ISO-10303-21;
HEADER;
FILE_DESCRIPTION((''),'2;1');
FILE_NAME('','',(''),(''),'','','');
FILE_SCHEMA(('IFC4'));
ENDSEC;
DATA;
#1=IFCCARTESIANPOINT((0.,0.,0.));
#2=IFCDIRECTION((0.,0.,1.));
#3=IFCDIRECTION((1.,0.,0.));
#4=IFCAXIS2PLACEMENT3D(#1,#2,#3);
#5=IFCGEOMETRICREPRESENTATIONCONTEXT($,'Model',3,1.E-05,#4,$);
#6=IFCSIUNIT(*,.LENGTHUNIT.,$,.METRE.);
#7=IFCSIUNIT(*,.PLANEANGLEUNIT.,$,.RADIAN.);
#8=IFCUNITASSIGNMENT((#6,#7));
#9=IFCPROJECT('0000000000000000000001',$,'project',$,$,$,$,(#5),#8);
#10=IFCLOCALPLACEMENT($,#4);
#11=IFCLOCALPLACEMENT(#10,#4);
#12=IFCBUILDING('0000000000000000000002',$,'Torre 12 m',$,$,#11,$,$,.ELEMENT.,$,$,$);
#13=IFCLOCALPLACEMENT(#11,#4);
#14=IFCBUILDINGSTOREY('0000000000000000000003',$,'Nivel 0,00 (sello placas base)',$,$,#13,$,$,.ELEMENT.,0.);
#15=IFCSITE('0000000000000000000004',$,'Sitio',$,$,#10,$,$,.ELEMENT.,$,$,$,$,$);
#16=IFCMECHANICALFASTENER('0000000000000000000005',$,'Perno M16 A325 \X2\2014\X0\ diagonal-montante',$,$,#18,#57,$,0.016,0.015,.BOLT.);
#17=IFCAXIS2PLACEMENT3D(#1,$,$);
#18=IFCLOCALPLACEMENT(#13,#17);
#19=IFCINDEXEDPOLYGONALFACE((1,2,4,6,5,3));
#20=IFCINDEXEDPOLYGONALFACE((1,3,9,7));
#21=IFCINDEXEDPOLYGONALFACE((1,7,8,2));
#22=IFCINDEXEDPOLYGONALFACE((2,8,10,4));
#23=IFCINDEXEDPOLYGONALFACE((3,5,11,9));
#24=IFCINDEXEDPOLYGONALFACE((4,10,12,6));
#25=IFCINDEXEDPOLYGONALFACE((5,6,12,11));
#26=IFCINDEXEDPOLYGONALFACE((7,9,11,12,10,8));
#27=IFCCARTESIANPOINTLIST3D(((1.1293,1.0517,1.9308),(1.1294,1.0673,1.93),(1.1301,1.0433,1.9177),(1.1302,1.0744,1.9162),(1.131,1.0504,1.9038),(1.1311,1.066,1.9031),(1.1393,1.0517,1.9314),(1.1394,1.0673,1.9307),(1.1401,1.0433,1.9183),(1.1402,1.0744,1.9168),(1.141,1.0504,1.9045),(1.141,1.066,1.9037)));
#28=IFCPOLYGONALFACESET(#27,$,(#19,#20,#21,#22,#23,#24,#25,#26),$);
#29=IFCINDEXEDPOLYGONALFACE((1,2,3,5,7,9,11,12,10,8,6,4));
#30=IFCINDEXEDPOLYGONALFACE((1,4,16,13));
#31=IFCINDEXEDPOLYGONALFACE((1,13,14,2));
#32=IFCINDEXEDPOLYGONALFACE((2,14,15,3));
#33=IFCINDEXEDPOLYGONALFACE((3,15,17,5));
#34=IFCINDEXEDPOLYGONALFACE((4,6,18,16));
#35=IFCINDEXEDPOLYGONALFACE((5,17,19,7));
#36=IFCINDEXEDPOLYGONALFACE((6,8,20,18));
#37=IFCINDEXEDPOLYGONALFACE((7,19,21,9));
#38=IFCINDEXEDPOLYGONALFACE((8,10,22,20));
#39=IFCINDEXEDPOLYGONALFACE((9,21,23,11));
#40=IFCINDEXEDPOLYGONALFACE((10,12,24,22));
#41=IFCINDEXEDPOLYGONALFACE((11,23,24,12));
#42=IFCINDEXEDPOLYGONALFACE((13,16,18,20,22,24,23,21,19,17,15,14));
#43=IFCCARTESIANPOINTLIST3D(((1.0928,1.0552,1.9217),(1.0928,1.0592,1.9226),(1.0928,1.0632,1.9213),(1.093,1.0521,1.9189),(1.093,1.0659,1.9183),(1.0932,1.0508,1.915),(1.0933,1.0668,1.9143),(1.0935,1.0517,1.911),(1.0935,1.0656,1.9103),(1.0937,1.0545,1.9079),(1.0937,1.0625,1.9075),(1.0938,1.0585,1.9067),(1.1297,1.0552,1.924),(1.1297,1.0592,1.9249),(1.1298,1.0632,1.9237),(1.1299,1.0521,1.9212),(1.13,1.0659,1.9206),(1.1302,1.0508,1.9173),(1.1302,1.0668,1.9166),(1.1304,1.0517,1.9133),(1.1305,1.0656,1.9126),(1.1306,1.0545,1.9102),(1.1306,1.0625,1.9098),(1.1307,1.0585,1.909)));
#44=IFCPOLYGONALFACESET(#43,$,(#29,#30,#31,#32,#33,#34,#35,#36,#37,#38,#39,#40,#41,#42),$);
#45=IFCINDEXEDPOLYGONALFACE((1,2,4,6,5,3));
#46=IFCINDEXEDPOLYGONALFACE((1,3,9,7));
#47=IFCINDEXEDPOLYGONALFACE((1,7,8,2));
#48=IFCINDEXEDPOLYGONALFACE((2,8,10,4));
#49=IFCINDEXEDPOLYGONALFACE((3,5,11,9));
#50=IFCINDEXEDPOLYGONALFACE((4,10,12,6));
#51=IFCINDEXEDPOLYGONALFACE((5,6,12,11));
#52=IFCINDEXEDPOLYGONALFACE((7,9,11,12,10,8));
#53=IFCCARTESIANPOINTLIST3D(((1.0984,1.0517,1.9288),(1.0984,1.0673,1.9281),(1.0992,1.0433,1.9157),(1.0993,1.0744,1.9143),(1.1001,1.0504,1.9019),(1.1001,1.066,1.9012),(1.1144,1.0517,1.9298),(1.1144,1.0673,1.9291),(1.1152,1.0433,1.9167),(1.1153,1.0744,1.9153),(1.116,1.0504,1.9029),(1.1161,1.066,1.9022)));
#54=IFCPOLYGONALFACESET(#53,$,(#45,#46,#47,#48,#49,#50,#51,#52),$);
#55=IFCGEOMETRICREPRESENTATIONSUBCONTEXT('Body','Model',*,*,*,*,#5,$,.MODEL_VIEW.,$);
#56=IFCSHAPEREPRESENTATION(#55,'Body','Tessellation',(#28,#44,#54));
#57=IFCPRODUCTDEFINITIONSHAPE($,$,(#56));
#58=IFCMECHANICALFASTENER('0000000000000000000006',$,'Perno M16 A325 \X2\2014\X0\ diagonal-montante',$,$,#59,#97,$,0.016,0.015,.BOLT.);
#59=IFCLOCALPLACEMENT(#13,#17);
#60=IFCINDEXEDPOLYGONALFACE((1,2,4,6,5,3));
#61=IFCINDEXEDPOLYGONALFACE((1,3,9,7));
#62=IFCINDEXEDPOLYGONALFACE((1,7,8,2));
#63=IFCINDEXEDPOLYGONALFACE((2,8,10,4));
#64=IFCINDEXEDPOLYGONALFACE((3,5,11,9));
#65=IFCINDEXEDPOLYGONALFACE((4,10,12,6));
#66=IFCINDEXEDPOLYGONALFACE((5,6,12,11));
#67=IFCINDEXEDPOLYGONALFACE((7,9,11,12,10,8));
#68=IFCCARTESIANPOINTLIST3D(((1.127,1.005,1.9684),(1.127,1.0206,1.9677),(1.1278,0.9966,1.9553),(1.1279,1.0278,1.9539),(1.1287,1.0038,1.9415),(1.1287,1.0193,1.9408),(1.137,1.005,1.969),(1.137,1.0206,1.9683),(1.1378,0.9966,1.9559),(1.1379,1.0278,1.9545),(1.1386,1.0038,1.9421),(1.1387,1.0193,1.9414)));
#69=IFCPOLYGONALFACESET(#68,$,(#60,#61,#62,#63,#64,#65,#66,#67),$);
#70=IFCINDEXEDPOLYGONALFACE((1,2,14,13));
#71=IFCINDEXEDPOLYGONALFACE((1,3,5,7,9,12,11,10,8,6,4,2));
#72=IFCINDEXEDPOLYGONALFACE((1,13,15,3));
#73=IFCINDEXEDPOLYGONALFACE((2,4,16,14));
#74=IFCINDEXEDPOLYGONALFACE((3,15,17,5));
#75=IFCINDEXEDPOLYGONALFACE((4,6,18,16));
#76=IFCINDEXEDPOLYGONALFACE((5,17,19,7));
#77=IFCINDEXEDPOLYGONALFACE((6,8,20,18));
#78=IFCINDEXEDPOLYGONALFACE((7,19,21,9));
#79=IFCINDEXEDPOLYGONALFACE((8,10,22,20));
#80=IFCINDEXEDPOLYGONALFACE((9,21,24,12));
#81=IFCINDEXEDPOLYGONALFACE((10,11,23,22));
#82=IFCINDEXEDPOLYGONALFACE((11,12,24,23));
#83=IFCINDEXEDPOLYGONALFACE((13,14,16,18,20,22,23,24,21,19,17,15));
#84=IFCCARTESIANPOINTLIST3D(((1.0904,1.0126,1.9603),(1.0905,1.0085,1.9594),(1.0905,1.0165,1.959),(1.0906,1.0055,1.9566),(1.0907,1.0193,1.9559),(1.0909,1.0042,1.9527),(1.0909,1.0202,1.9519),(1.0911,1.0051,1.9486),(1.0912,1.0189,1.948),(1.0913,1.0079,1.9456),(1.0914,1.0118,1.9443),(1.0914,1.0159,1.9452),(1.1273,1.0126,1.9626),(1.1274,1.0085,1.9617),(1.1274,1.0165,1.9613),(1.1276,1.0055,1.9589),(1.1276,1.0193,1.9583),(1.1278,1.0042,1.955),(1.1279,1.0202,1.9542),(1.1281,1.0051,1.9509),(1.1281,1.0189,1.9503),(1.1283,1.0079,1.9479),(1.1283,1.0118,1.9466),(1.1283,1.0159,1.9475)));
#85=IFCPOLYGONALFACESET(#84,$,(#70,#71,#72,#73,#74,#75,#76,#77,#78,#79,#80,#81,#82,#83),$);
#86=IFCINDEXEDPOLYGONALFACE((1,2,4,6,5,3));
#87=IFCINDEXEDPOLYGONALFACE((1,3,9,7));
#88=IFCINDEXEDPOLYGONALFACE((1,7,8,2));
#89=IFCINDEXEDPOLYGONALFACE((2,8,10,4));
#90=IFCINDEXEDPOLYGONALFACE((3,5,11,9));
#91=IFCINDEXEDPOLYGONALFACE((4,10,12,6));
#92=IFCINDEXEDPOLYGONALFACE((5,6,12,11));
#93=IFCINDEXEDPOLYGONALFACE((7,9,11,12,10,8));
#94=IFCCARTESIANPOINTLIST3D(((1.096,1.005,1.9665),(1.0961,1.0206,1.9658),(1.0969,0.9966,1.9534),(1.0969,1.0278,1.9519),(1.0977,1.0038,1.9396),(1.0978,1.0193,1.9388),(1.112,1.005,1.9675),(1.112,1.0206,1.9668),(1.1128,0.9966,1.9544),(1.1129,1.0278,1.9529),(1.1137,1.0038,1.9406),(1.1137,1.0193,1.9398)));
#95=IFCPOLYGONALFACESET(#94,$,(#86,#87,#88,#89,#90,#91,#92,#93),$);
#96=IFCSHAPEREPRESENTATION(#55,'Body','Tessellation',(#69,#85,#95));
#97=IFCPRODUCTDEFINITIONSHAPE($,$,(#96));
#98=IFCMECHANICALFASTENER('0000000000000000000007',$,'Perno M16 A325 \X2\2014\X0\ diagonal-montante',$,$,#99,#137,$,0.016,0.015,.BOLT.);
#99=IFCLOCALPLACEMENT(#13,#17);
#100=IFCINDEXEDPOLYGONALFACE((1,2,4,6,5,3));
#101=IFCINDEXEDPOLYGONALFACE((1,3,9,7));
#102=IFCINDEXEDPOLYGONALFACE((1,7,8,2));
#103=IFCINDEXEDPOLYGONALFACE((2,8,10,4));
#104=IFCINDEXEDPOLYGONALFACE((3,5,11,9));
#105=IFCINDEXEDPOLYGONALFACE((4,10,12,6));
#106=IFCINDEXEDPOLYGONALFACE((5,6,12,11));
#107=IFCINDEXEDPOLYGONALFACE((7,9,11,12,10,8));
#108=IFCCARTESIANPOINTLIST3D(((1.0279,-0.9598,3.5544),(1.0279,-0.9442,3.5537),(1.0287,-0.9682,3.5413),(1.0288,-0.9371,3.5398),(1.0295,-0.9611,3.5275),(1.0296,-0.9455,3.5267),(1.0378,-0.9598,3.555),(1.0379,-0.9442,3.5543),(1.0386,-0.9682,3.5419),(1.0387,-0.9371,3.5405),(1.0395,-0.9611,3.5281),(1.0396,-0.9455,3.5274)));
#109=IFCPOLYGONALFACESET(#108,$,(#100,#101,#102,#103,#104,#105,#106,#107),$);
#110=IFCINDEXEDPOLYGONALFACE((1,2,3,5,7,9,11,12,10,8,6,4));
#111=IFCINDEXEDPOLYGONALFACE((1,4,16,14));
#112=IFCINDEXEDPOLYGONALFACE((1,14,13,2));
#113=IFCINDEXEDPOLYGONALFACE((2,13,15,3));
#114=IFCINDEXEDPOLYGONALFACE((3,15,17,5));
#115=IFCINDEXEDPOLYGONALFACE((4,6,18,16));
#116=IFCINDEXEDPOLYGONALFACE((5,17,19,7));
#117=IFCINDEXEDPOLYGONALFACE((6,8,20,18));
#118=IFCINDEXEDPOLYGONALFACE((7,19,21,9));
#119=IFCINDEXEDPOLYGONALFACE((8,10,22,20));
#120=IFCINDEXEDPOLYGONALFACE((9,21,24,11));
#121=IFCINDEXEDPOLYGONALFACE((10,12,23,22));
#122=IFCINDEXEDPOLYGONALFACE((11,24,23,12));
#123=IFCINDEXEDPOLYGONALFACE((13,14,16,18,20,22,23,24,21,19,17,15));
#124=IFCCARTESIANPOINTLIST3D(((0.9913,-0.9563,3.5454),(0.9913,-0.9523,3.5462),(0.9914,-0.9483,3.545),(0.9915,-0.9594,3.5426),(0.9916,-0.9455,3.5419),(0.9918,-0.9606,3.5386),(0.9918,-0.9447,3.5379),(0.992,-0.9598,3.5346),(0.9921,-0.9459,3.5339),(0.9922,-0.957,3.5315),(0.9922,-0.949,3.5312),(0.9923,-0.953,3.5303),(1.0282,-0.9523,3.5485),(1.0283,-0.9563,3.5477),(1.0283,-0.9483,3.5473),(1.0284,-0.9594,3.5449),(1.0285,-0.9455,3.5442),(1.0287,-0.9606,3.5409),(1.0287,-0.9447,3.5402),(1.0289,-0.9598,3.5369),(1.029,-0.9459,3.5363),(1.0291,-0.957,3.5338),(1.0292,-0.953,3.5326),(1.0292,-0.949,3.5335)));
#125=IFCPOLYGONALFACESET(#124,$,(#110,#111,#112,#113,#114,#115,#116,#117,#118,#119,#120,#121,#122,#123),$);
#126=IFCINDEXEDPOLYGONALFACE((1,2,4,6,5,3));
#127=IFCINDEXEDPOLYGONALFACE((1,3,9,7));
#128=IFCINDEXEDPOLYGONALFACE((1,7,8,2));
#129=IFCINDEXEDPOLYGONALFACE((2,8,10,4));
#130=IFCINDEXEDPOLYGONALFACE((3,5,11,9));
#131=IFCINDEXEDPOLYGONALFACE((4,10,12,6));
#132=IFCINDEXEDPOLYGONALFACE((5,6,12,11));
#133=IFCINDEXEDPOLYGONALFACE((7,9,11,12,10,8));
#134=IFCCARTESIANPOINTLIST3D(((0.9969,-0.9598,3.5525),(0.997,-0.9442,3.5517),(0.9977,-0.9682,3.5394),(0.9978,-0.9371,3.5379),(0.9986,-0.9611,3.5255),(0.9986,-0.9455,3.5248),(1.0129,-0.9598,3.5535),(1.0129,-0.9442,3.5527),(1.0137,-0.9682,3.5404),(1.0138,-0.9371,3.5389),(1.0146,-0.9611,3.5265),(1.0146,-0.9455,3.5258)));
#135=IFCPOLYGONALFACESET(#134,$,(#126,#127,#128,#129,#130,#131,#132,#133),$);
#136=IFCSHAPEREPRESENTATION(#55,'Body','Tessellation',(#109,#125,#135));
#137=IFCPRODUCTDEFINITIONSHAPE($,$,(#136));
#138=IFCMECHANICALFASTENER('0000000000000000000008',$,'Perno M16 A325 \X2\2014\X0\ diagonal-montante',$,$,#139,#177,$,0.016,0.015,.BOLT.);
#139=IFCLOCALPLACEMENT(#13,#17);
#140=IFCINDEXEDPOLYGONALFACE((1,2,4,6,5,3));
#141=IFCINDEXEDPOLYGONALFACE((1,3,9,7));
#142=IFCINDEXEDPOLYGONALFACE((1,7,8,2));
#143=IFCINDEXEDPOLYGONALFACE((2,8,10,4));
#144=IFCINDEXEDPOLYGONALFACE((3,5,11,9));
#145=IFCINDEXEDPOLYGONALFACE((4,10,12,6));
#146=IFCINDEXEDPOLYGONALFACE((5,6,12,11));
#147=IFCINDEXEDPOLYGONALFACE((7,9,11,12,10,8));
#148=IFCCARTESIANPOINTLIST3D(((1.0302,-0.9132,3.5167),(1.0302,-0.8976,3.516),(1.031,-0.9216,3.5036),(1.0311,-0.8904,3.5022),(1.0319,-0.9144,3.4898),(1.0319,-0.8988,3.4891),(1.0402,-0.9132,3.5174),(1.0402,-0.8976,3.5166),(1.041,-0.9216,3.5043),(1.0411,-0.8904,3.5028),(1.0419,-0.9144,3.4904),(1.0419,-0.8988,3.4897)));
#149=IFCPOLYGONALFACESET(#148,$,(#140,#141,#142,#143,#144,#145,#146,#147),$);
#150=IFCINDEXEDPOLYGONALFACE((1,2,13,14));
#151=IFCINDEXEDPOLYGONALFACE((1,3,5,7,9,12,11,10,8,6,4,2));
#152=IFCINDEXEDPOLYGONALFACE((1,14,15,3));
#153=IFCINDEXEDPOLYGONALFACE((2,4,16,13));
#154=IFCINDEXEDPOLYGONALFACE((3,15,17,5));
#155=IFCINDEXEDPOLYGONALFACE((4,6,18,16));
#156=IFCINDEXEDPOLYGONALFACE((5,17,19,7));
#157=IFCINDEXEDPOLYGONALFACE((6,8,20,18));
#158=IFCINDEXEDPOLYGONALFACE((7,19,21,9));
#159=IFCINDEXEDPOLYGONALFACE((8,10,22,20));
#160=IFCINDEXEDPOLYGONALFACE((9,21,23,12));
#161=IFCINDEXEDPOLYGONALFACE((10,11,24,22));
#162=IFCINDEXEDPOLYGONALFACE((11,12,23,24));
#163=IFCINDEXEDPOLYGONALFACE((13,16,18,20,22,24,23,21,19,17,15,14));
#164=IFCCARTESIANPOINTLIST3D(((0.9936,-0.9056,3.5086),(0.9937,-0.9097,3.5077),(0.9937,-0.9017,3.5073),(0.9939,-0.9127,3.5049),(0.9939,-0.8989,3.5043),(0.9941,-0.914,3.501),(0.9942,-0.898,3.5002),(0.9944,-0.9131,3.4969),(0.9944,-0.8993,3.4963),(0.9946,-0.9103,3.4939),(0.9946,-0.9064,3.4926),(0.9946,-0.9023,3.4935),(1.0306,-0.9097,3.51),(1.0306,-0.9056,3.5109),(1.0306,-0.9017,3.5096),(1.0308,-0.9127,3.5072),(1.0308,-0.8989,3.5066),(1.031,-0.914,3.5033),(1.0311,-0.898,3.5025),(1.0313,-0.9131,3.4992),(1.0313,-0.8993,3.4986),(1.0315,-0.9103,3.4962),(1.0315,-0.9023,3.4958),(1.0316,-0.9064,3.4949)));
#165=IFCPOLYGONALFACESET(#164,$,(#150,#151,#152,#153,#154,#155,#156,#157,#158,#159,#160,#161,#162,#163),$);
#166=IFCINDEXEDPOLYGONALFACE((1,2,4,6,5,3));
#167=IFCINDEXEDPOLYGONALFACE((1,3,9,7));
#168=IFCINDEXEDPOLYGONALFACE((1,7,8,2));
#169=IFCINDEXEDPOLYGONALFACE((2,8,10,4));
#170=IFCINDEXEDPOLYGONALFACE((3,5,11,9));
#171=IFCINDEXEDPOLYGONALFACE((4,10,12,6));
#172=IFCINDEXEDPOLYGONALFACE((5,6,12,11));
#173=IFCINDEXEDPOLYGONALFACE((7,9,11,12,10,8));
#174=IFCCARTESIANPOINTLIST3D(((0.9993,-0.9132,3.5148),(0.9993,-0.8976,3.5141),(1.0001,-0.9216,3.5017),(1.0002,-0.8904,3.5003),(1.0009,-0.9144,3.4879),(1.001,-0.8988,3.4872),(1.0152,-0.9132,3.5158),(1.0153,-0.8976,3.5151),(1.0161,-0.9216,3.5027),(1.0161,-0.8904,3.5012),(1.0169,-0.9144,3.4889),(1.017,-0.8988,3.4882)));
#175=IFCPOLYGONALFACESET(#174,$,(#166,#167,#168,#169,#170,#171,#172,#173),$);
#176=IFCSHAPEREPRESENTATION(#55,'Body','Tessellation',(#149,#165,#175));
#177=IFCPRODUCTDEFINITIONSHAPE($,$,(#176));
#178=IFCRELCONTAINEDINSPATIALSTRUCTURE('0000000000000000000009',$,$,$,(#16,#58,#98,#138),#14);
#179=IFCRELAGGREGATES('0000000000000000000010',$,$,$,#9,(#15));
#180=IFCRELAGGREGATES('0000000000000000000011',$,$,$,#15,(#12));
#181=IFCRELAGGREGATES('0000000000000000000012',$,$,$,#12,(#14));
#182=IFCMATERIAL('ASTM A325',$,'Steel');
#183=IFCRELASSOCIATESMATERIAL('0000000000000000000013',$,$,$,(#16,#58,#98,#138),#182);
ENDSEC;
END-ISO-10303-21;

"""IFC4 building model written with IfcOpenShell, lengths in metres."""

from ifc_helpers import new_model, si_unit, frame, origin_with_axes, place, context, subcontext, project, spatial, polyline, outline, extrude, material, element, save


model = new_model("IFC4")

# Units and contexts
model_context = context("Model", 3, precision=1e-05, world=origin_with_axes())
body_context = subcontext(model_context, "Body", "Model", "MODEL_VIEW")
ifc_project = project(units=[si_unit("LENGTHUNIT", "METRE"), si_unit("PLANEANGLEUNIT", "RADIAN")], contexts=[model_context])

# Site, building, storey
site_placement = place(None, origin_with_axes())
site = spatial("IfcSite", under=ifc_project, at=site_placement, Name="Sitio", CompositionType="ELEMENT")
building_placement = place(site_placement, origin_with_axes())
building = spatial("IfcBuilding", under=site, at=building_placement, Name="Torre 12 m", CompositionType="ELEMENT")
storey_placement = place(building_placement, origin_with_axes())
storey = spatial("IfcBuildingStorey", under=building, at=storey_placement, Name="Nivel 0,00 (sello placas base)", CompositionType="ELEMENT", Elevation=0.0)

# Shared definitions
placement = place(storey_placement, origin_with_axes())

# Mechanical fasteners
ifc_material_1 = material(Name="ASTM A325", Category="Steel")
element("IfcMechanicalFastener", 1, at=placement, inside=storey, material=ifc_material_1, Name="Perno M16 A325 — diagonal-montante", NominalDiameter=0.016, NominalLength=0.015, PredefinedType="BOLT", context=body_context, shape_type="SweptSolid", body=[
    extrude(outline(polyline([(0.0135, 0.0078), (0.0, 0.0156), (-0.0135, 0.0078), (-0.0135, -0.0078), (0.0, -0.0156), (0.0135, -0.0078), (0.0135, 0.0078)])), frame((1.1402, 1.0588, 1.9176), z_axis=(-0.998053, 0.0, -0.062378), x_axis=(0.033672, 0.841794, -0.538748)), (0.0, 0.0, 1.0), 0.01),
    extrude(outline(polyline([(0.008, 0.0), (0.0069, 0.004), (0.004, 0.0069), (0.0, 0.008), (-0.004, 0.0069), (-0.0069, 0.004), (-0.008, 0.0), (-0.0069, -0.004), (-0.004, -0.0069), (0.0, -0.008), (0.004, -0.0069), (0.0069, -0.004), (0.008, 0.0)])), frame((1.1302, 1.0588, 1.9169), z_axis=(-0.998053, 0.0, -0.062378), x_axis=(0.033672, 0.841794, -0.538748)), (0.0, 0.0, 1.0), 0.037),
    extrude(outline(polyline([(0.0135, 0.0078), (0.0, 0.0156), (-0.0135, 0.0078), (-0.0135, -0.0078), (0.0, -0.0156), (0.0135, -0.0078), (0.0135, 0.0078)])), frame((1.1152, 1.0588, 1.916), z_axis=(-0.998053, 0.0, -0.062378), x_axis=(0.033672, 0.841794, -0.538748)), (0.0, 0.0, 1.0), 0.016),
])
element("IfcMechanicalFastener", 2, at=placement, inside=storey, material=ifc_material_1, Name="Perno M16 A325 — diagonal-montante", NominalDiameter=0.016, NominalLength=0.015, PredefinedType="BOLT", context=body_context, shape_type="SweptSolid", body=[
    extrude(outline(polyline([(0.0135, 0.0078), (0.0, 0.0156), (-0.0135, 0.0078), (-0.0135, -0.0078), (0.0, -0.0156), (0.0135, -0.0078), (0.0135, 0.0078)])), frame((1.1378, 1.0122, 1.9552), z_axis=(-0.998053, 0.0, -0.062378), x_axis=(0.033672, 0.841794, -0.538748)), (0.0, 0.0, 1.0), 0.01),
    extrude(outline(polyline([(0.008, 0.0), (0.0069, 0.004), (0.004, 0.0069), (0.0, 0.008), (-0.004, 0.0069), (-0.0069, 0.004), (-0.008, 0.0), (-0.0069, -0.004), (-0.004, -0.0069), (0.0, -0.008), (0.004, -0.0069), (0.0069, -0.004), (0.008, 0.0)])), frame((1.1278, 1.0122, 1.9546), z_axis=(-0.998053, 0.0, -0.062378), x_axis=(0.033672, 0.841794, -0.538748)), (0.0, 0.0, 1.0), 0.037),
    extrude(outline(polyline([(0.0135, 0.0078), (0.0, 0.0156), (-0.0135, 0.0078), (-0.0135, -0.0078), (0.0, -0.0156), (0.0135, -0.0078), (0.0135, 0.0078)])), frame((1.1129, 1.0122, 1.9537), z_axis=(-0.998053, 0.0, -0.062378), x_axis=(0.033672, 0.841794, -0.538748)), (0.0, 0.0, 1.0), 0.016),
])
element("IfcMechanicalFastener", 3, at=placement, inside=storey, material=ifc_material_1, Name="Perno M16 A325 — diagonal-montante", NominalDiameter=0.016, NominalLength=0.015, PredefinedType="BOLT", context=body_context, shape_type="SweptSolid", body=[
    extrude(outline(polyline([(0.0135, 0.0078), (0.0, 0.0156), (-0.0135, 0.0078), (-0.0135, -0.0078), (0.0, -0.0156), (0.0135, -0.0078), (0.0135, 0.0078)])), frame((1.0387, -0.9527, 3.5412), z_axis=(-0.998053, 0.0, -0.062378), x_axis=(0.033672, 0.841794, -0.538748)), (0.0, 0.0, 1.0), 0.01),
    extrude(outline(polyline([(0.008, 0.0), (0.0069, 0.004), (0.004, 0.0069), (0.0, 0.008), (-0.004, 0.0069), (-0.0069, 0.004), (-0.008, 0.0), (-0.0069, -0.004), (-0.004, -0.0069), (0.0, -0.008), (0.004, -0.0069), (0.0069, -0.004), (0.008, 0.0)])), frame((1.0287, -0.9527, 3.5406), z_axis=(-0.998053, 0.0, -0.062378), x_axis=(0.033672, 0.841794, -0.538748)), (0.0, 0.0, 1.0), 0.037),
    extrude(outline(polyline([(0.0135, 0.0078), (0.0, 0.0156), (-0.0135, 0.0078), (-0.0135, -0.0078), (0.0, -0.0156), (0.0135, -0.0078), (0.0135, 0.0078)])), frame((1.0137, -0.9527, 3.5396), z_axis=(-0.998053, 0.0, -0.062378), x_axis=(0.033672, 0.841794, -0.538748)), (0.0, 0.0, 1.0), 0.016),
])
element("IfcMechanicalFastener", 4, at=placement, inside=storey, material=ifc_material_1, Name="Perno M16 A325 — diagonal-montante", NominalDiameter=0.016, NominalLength=0.015, PredefinedType="BOLT", context=body_context, shape_type="SweptSolid", body=[
    extrude(outline(polyline([(0.0135, 0.0078), (0.0, 0.0156), (-0.0135, 0.0078), (-0.0135, -0.0078), (0.0, -0.0156), (0.0135, -0.0078), (0.0135, 0.0078)])), frame((1.041, -0.906, 3.5035), z_axis=(-0.998053, 0.0, -0.062378), x_axis=(0.033672, 0.841794, -0.538748)), (0.0, 0.0, 1.0), 0.01),
    extrude(outline(polyline([(0.008, 0.0), (0.0069, 0.004), (0.004, 0.0069), (0.0, 0.008), (-0.004, 0.0069), (-0.0069, 0.004), (-0.008, 0.0), (-0.0069, -0.004), (-0.004, -0.0069), (0.0, -0.008), (0.004, -0.0069), (0.0069, -0.004), (0.008, 0.0)])), frame((1.0311, -0.906, 3.5029), z_axis=(-0.998053, 0.0, -0.062378), x_axis=(0.033672, 0.841794, -0.538748)), (0.0, 0.0, 1.0), 0.037),
    extrude(outline(polyline([(0.0135, 0.0078), (0.0, 0.0156), (-0.0135, 0.0078), (-0.0135, -0.0078), (0.0, -0.0156), (0.0135, -0.0078), (0.0135, 0.0078)])), frame((1.0161, -0.906, 3.502), z_axis=(-0.998053, 0.0, -0.062378), x_axis=(0.033672, 0.841794, -0.538748)), (0.0, 0.0, 1.0), 0.016),
])

save(model, "model.ifc")
